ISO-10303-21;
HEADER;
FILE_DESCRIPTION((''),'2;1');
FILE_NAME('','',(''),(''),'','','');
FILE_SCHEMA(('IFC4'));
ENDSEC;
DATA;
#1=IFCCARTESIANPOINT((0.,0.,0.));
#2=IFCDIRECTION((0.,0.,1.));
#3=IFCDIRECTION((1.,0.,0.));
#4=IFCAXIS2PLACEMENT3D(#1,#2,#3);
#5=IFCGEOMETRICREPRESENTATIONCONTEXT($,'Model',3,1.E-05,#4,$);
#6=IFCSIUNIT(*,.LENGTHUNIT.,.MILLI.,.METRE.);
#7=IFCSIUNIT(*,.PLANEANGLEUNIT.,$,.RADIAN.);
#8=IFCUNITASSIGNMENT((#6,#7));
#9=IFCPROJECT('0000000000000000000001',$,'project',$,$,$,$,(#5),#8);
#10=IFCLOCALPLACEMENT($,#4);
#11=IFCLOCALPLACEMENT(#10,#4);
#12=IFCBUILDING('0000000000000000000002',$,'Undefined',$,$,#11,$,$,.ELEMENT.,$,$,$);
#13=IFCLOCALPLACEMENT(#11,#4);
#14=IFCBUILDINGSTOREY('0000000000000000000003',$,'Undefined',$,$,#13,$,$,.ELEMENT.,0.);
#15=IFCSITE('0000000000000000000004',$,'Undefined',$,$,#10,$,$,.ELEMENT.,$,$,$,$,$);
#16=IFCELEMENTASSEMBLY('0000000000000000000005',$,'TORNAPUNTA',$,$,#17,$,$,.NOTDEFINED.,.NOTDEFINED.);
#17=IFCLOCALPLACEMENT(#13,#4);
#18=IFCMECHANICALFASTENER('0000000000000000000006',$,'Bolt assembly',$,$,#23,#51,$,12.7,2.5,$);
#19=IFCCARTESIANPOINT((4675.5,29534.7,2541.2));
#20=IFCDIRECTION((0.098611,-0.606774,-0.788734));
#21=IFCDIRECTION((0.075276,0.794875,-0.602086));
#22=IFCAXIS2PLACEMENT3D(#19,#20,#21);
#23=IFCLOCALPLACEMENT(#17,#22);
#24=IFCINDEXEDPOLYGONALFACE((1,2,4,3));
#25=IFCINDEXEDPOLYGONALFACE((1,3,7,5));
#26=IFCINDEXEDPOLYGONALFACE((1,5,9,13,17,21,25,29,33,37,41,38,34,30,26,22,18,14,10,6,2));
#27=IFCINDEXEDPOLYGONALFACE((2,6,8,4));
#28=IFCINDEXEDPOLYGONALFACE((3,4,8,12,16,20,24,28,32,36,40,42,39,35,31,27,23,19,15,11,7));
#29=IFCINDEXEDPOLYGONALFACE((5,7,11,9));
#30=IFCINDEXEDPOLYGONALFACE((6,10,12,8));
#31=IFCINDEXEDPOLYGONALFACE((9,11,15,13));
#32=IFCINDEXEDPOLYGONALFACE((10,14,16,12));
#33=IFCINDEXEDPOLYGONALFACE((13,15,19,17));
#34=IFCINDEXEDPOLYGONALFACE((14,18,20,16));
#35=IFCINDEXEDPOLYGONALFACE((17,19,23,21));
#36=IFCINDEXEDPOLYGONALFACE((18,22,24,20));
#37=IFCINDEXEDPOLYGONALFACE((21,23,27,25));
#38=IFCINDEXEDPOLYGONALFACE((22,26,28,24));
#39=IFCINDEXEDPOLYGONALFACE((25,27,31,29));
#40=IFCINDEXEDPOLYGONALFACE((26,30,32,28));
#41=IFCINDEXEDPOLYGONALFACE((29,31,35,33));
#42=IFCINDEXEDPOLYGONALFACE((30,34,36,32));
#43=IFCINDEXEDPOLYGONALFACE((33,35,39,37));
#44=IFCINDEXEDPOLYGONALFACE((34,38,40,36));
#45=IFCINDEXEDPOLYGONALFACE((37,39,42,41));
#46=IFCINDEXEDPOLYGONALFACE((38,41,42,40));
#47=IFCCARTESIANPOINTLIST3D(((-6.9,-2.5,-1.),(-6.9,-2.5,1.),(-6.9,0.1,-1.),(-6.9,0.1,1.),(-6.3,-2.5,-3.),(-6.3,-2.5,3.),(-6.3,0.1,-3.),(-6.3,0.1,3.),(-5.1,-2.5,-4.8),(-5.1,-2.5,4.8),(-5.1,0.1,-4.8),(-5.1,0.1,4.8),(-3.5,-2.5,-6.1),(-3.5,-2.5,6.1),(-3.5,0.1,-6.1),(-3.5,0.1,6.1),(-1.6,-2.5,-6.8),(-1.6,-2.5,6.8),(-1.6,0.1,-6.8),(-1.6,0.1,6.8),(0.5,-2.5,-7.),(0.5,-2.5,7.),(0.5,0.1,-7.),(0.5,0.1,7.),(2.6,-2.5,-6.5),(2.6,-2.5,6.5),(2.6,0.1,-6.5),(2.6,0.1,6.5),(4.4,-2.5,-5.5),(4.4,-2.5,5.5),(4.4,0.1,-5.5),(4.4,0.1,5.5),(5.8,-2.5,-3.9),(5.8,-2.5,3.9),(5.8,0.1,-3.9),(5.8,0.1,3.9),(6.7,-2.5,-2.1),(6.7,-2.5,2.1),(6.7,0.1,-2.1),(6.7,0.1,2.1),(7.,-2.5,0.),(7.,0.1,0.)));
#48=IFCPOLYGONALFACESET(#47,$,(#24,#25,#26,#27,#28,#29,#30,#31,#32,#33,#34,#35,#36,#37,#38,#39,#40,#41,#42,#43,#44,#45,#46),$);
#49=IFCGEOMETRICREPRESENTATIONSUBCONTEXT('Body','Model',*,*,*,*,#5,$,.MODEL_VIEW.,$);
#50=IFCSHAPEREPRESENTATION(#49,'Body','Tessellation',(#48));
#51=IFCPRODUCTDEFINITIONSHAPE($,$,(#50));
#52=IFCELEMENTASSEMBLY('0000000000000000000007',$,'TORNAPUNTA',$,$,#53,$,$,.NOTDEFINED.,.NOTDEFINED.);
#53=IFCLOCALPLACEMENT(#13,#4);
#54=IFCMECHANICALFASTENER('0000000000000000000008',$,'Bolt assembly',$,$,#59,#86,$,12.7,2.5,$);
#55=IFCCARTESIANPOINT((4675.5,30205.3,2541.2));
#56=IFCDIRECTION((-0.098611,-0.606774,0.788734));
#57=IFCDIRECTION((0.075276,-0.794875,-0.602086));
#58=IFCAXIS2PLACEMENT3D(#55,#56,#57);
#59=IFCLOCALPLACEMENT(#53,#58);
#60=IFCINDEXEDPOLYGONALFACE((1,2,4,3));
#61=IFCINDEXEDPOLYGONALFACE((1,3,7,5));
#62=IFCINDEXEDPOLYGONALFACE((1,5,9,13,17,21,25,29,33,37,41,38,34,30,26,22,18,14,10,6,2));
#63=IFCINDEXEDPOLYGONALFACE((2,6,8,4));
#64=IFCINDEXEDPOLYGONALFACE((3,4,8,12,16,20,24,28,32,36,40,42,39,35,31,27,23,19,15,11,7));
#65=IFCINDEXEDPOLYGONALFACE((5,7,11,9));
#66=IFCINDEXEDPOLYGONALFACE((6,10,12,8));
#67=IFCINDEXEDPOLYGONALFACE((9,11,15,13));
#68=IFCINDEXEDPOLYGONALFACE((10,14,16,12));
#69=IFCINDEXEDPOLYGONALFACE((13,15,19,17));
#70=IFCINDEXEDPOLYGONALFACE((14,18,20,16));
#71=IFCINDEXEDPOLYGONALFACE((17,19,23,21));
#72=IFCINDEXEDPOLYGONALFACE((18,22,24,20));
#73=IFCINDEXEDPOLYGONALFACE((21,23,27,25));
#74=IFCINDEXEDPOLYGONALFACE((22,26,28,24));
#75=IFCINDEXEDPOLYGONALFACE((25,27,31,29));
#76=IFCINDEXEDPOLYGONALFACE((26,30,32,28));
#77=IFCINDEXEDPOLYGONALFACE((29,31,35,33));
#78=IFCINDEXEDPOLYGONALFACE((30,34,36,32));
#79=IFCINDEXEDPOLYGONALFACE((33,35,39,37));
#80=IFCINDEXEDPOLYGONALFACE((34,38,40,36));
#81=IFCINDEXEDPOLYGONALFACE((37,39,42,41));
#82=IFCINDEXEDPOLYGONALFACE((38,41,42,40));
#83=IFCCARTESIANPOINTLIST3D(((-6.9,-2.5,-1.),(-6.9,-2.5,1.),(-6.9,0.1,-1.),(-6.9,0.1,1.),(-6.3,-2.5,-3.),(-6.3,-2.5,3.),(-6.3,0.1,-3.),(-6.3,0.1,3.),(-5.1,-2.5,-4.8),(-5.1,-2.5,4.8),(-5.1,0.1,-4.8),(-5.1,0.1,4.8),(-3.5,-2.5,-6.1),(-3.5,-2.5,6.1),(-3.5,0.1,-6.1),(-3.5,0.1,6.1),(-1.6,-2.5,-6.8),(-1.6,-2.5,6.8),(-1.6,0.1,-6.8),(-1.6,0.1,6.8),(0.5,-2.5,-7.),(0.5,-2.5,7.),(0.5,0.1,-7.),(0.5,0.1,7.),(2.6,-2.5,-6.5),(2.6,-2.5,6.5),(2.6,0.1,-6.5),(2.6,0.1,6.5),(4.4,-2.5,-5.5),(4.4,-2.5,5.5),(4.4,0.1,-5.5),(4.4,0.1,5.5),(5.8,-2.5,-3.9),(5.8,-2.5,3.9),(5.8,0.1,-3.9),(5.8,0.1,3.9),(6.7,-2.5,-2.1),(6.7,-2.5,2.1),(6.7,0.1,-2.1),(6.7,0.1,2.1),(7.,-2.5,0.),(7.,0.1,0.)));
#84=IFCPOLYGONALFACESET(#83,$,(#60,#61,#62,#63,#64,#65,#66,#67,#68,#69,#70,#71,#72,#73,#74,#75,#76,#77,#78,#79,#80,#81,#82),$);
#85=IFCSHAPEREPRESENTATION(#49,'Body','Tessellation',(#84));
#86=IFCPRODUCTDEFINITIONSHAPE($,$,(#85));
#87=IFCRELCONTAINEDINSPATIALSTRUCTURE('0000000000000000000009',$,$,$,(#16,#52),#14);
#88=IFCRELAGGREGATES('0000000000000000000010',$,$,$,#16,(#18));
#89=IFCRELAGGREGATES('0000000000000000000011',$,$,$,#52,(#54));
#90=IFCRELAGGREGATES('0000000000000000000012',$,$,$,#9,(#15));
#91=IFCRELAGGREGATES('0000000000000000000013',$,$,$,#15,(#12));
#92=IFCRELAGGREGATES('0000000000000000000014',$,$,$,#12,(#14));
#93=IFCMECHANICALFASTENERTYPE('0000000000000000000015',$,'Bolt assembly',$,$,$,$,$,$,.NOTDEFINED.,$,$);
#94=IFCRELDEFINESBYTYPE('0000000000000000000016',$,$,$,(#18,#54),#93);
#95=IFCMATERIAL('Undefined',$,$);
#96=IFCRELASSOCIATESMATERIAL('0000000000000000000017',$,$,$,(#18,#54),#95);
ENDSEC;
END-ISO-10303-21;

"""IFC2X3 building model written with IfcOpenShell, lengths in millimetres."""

from ifc_helpers import new_model, si_unit, frame, origin_with_axes, origin_2d_with_axis, place, context, subcontext, project, spatial, circle, extrude, source, transform, mapped, material, type_object, element, aggregate, save


model = new_model("IFC2X3")

# Units and contexts
model_context = context("Model", 3, precision=1e-05, world=origin_with_axes())
body_context = subcontext(model_context, "Body", "Model", "MODEL_VIEW")
ifc_project = project(units=[si_unit("LENGTHUNIT", "METRE", prefix="MILLI"), si_unit("PLANEANGLEUNIT", "RADIAN")], contexts=[model_context])

# Site, building, storey
site_placement = place(None, origin_with_axes())
site = spatial("IfcSite", under=ifc_project, at=site_placement, Name="Undefined", CompositionType="ELEMENT")
building_placement = place(site_placement, origin_with_axes())
building = spatial("IfcBuilding", under=site, at=building_placement, Name="Undefined", CompositionType="ELEMENT")
storey_placement = place(building_placement, origin_with_axes())
storey = spatial("IfcBuildingStorey", under=building, at=storey_placement, Name="Undefined", CompositionType="ELEMENT", Elevation=0.0)

# Shared definitions
ifc_material_1 = material(Name="Undefined")
mechanical_fastener_type = type_object("IfcMechanicalFastenerType", Name="Bolt assembly")

# Element assemblies, mechanical fasteners
assembly_1_placement = place(storey_placement, origin_with_axes())
assembly_1 = element("IfcElementAssembly", 1, at=assembly_1_placement, inside=storey, Name="TORNAPUNTA", AssemblyPlace="NOTDEFINED", PredefinedType="NOTDEFINED")
shared_shape_1 = source(origin_with_axes(), body_context, "Body", "SweptSolid", [
    extrude(circle(Radius=7.0, at=origin_2d_with_axis()), frame((0.0, -2.5, 0.0), z_axis=(0.0, 1.0, 0.0), x_axis=(1.0, 0.0, 0.0)), (0.0, 0.0, 1.0), 2.6),
])
mechanical_fastener_1_placement = place(assembly_1_placement, frame((4675.5, 29534.7, 2541.2), z_axis=(0.098611, -0.606774, -0.788734), x_axis=(0.075276, 0.794875, -0.602086)))
mechanical_fastener_1 = element("IfcMechanicalFastener", 2, at=mechanical_fastener_1_placement, type_object=mechanical_fastener_type, material=ifc_material_1, Name="Bolt assembly", NominalDiameter=12.7, NominalLength=2.5, context=body_context, shape_type="MappedRepresentation", body=[
    mapped(shared_shape_1, transform((0.0, 0.0, 0.0))),
])
aggregate(assembly_1, [mechanical_fastener_1])
assembly_2_placement = place(storey_placement, origin_with_axes())
assembly_2 = element("IfcElementAssembly", 3, at=assembly_2_placement, inside=storey, Name="TORNAPUNTA", AssemblyPlace="NOTDEFINED", PredefinedType="NOTDEFINED")
mechanical_fastener_2_placement = place(assembly_2_placement, frame((4675.5, 30205.3, 2541.2), z_axis=(-0.098611, -0.606774, 0.788734), x_axis=(0.075276, -0.794875, -0.602086)))
mechanical_fastener_2 = element("IfcMechanicalFastener", 4, at=mechanical_fastener_2_placement, type_object=mechanical_fastener_type, material=ifc_material_1, Name="Bolt assembly", NominalDiameter=12.7, NominalLength=2.5, context=body_context, shape_type="MappedRepresentation", body=[
    mapped(shared_shape_1, transform((0.0, 0.0, 0.0))),
])
aggregate(assembly_2, [mechanical_fastener_2])

save(model, "model.ifc")
